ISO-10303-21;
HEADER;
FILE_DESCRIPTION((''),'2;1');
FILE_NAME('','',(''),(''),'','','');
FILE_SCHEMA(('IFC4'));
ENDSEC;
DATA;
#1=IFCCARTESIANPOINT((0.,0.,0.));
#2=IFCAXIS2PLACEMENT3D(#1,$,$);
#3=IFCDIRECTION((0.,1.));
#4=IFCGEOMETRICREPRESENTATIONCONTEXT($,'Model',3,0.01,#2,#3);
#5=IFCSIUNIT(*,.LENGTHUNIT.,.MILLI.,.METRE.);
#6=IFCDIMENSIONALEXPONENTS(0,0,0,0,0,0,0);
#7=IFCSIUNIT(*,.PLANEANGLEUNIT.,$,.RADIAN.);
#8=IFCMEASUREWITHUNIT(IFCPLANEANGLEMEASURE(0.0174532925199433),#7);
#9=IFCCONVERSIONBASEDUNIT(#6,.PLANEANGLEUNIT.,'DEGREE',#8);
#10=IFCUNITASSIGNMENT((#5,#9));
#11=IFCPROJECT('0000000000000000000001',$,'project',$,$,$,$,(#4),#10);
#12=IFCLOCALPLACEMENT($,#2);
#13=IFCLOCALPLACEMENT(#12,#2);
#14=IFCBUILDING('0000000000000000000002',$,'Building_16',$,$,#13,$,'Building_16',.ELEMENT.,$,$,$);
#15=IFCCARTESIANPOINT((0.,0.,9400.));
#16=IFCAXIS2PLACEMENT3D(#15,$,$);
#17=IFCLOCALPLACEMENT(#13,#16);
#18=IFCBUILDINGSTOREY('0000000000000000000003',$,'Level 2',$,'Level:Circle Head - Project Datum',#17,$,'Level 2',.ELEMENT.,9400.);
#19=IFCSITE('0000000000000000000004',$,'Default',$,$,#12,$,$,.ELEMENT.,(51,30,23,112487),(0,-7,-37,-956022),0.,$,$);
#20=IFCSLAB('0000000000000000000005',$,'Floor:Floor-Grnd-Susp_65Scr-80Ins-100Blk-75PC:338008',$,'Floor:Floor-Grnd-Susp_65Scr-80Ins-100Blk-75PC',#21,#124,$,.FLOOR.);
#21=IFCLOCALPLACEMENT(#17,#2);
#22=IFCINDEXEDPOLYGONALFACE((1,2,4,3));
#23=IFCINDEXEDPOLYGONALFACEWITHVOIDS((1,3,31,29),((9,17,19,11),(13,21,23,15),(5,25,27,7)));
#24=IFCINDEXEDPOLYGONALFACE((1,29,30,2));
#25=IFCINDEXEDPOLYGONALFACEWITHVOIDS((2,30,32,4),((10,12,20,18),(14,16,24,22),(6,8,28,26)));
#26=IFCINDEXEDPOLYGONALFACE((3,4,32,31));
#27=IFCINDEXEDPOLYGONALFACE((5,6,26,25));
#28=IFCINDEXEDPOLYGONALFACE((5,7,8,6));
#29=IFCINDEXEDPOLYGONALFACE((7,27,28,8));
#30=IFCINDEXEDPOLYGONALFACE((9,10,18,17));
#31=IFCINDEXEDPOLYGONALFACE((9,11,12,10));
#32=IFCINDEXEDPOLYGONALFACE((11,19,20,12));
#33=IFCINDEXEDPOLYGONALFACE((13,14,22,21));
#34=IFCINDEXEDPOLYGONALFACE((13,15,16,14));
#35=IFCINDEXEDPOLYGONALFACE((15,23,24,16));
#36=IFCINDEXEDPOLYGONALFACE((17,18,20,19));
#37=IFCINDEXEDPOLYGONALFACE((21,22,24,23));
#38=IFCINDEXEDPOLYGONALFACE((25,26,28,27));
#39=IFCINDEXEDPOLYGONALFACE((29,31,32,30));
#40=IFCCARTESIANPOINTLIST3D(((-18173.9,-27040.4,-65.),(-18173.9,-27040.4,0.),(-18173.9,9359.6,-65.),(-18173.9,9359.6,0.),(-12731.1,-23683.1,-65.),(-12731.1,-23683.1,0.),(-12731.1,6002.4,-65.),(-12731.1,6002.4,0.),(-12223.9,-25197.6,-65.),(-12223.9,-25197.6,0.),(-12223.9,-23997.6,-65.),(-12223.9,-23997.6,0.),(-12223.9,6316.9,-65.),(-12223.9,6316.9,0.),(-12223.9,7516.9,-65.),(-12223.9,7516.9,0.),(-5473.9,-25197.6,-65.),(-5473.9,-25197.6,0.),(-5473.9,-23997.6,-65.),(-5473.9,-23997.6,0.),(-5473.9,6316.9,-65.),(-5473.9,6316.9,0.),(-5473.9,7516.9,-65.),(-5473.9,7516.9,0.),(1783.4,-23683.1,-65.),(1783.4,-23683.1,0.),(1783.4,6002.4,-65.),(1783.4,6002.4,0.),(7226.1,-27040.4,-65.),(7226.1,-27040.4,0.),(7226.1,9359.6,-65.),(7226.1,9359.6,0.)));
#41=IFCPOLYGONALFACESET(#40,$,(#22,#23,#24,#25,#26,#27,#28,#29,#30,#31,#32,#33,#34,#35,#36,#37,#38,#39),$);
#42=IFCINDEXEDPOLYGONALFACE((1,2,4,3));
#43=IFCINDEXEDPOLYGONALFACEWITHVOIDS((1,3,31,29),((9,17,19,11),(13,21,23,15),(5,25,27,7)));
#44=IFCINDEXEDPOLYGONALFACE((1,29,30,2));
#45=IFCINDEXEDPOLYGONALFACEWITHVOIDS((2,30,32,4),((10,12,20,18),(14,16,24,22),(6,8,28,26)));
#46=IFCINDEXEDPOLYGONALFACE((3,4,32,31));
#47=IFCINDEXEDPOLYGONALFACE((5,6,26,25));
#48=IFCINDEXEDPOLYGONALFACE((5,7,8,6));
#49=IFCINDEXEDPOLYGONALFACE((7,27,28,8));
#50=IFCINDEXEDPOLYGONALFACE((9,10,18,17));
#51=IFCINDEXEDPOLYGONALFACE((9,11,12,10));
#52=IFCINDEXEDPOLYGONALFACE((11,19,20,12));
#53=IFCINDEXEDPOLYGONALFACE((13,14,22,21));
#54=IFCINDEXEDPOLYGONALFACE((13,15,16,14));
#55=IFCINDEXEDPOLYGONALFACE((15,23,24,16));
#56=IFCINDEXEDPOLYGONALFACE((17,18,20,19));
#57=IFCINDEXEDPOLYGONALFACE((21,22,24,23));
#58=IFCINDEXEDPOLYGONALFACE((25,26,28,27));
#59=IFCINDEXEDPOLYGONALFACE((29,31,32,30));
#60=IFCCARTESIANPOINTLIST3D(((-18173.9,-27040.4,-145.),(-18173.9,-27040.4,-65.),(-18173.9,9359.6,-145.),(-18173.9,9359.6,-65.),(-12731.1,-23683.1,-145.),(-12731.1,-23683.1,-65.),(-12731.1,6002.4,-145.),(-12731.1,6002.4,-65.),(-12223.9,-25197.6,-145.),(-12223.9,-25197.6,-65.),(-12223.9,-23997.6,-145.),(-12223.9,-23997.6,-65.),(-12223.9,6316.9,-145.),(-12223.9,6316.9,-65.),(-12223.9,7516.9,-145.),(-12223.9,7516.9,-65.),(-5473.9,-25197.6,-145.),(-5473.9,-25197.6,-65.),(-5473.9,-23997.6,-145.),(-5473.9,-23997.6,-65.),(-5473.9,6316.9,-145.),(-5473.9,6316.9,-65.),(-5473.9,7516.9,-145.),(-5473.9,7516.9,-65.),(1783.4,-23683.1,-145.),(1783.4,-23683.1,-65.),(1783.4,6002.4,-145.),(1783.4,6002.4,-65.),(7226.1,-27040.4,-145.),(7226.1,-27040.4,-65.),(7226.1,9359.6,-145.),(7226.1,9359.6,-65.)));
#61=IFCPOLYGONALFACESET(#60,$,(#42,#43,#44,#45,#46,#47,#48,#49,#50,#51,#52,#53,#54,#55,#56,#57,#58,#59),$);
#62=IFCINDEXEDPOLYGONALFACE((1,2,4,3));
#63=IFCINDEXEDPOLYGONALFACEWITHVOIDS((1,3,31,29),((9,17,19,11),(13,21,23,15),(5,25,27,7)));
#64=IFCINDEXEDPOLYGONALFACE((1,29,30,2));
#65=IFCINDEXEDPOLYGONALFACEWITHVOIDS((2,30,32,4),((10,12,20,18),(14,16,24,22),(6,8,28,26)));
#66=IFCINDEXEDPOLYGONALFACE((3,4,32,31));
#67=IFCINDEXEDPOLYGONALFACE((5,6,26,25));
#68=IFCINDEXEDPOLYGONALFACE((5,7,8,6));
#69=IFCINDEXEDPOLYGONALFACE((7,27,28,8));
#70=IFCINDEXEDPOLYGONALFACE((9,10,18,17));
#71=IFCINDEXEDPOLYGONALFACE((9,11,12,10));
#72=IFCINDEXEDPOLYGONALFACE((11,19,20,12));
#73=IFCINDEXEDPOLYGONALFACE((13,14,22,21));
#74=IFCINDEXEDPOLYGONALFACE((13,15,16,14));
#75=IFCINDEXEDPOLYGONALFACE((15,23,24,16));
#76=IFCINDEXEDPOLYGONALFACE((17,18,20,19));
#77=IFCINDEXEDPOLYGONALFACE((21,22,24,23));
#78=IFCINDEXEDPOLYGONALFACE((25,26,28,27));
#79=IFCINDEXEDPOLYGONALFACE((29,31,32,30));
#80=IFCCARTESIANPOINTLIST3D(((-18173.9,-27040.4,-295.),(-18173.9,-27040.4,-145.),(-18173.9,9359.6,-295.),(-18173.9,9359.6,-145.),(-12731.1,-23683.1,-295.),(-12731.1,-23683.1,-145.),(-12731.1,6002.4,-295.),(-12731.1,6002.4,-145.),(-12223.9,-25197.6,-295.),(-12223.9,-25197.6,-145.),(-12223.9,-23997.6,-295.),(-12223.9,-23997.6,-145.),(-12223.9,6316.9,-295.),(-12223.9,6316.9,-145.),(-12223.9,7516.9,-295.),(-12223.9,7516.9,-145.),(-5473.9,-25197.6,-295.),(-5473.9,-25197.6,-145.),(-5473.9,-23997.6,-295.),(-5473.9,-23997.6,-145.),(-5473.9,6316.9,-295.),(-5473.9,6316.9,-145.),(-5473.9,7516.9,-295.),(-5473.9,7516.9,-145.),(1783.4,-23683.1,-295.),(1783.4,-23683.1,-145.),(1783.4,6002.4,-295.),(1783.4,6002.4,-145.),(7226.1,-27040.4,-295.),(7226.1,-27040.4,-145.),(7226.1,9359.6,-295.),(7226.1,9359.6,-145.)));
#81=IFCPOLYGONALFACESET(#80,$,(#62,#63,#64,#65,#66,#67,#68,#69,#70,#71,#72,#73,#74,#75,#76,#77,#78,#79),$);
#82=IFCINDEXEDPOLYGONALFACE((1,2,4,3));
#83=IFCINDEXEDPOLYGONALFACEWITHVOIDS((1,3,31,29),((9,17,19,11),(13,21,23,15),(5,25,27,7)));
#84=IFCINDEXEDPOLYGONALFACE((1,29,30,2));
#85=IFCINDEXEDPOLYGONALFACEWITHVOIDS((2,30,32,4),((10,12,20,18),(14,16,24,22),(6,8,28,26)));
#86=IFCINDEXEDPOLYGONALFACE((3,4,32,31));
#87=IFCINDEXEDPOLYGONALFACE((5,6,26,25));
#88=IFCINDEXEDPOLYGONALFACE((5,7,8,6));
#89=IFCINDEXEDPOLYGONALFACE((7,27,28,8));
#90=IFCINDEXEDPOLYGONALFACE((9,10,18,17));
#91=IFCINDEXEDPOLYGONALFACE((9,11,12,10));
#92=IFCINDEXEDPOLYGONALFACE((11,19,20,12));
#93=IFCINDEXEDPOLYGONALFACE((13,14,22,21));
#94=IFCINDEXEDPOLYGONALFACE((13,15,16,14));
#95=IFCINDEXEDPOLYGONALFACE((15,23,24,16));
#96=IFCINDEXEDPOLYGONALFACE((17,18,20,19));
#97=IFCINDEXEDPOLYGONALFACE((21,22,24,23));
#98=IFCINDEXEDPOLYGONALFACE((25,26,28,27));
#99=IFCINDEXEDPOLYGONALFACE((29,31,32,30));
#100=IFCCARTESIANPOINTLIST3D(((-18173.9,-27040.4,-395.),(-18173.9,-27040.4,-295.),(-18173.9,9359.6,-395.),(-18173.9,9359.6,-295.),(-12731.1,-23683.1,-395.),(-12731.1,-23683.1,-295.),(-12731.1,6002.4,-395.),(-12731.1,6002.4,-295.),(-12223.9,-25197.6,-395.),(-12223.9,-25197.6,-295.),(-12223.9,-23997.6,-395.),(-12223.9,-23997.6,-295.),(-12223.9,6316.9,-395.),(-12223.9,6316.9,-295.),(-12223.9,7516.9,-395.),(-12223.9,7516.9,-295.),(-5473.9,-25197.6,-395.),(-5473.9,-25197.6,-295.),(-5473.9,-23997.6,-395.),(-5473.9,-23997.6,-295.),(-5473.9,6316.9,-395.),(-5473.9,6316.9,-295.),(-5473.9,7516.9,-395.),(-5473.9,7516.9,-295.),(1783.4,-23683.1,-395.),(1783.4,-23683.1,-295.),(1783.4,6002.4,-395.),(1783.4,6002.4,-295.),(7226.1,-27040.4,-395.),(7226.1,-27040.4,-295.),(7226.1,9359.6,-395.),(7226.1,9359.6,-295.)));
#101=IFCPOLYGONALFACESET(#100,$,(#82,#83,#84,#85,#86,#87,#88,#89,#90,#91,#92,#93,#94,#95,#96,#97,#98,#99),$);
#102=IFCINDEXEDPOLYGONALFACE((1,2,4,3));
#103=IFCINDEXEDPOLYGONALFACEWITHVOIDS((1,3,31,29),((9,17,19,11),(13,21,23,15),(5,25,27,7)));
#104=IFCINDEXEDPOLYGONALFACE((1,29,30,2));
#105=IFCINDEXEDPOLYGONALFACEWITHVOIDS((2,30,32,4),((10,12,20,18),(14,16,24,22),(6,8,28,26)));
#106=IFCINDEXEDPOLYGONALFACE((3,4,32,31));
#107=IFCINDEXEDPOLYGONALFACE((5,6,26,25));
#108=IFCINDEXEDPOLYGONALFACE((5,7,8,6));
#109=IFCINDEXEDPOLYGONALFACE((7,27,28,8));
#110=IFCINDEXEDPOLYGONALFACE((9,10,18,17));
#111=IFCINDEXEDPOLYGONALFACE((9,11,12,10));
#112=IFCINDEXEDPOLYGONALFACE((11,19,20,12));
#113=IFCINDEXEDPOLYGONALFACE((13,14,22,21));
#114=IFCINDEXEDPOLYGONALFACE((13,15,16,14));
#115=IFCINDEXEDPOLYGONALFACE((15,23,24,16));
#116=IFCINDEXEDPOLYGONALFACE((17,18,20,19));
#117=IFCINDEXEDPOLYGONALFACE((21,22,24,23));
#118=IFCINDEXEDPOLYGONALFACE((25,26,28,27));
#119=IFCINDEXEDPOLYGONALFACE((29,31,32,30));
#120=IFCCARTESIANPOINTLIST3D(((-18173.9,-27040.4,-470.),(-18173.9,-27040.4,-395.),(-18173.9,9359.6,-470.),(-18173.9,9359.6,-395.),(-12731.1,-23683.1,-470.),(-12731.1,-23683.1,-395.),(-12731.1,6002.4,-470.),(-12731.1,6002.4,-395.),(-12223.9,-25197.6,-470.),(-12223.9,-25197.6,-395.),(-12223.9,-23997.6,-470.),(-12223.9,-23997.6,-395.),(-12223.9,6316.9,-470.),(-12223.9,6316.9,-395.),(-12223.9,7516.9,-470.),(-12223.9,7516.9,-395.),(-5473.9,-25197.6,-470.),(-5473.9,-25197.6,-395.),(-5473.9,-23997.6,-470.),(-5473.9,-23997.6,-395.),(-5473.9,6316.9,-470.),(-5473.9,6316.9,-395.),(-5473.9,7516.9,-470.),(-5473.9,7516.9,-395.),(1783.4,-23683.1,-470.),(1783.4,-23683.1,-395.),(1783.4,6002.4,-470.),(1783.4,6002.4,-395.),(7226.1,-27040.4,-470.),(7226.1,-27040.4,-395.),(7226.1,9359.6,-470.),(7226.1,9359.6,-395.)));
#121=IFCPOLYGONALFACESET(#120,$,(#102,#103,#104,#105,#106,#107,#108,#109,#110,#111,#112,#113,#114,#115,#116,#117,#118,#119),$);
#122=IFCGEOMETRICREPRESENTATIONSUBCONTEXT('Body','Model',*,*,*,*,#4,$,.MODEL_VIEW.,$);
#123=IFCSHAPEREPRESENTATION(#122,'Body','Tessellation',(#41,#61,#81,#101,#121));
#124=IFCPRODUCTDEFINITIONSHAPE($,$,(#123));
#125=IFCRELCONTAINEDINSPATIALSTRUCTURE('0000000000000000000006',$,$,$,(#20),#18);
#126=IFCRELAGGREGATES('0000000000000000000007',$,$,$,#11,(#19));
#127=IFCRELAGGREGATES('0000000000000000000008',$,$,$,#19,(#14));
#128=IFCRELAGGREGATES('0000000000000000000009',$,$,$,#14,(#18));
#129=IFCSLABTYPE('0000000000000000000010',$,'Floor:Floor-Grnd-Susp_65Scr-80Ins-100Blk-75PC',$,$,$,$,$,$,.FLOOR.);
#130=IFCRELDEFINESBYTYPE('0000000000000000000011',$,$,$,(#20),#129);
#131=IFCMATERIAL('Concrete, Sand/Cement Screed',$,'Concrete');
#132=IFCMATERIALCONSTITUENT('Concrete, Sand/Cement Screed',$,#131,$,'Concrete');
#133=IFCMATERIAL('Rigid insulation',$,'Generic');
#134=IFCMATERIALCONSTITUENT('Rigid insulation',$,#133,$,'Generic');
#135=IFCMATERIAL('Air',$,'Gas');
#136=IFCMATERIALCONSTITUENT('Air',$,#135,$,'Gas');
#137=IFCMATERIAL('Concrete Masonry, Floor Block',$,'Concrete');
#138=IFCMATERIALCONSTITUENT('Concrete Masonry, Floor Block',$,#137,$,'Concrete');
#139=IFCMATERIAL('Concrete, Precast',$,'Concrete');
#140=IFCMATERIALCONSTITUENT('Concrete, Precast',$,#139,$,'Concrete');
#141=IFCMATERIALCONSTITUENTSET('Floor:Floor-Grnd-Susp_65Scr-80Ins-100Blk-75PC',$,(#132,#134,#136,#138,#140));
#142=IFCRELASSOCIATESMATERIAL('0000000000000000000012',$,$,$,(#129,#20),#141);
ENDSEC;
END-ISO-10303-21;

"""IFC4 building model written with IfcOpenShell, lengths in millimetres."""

from ifc_helpers import new_model, entity, si_unit, converted_unit, direction, frame, origin, place, context, subcontext, project, spatial, indexed_curve, outline, extrude, material, constituent, constituent_set, type_object, element, save


model = new_model("IFC4")

# Units and contexts
model_context = context("Model", 3, precision=0.01, world=origin(), true_north=direction((0.0, 1.0)))
body_context = subcontext(model_context, "Body", "Model", "MODEL_VIEW")
ifc_project = project(units=[si_unit("LENGTHUNIT", "METRE", prefix="MILLI"), converted_unit("PLANEANGLEUNIT", "DEGREE", entity("IfcPlaneAngleMeasure", 0.0174532925199433), si_unit("PLANEANGLEUNIT", "RADIAN"), dimensions=[0, 0, 0, 0, 0, 0, 0])], contexts=[model_context])

# Site, building, storey
site_placement = place(None, origin())
site = spatial("IfcSite", under=ifc_project, at=site_placement, Name="Default", CompositionType="ELEMENT", RefLatitude=(51, 30, 23, 112487), RefLongitude=(0, -7, -37, -956022), RefElevation=0.0)
building_placement = place(site_placement, origin())
building = spatial("IfcBuilding", under=site, at=building_placement, Name="Building_16", LongName="Building_16", CompositionType="ELEMENT")
storey_placement = place(building_placement, frame((0.0, 0.0, 9400.0)))
storey = spatial("IfcBuildingStorey", under=building, at=storey_placement, Name="Level 2", ObjectType="Level:Circle Head - Project Datum", LongName="Level 2", CompositionType="ELEMENT", Elevation=9400.0)

# Slab, openings
ifc_material_1 = material(Name="Concrete, Sand/Cement Screed", Category="Concrete")
ifc_constituent_1 = constituent(ifc_material_1, Name="Concrete, Sand/Cement Screed", Category="Concrete")
ifc_material_2 = material(Name="Rigid insulation", Category="Generic")
ifc_constituent_2 = constituent(ifc_material_2, Name="Rigid insulation", Category="Generic")
ifc_material_3 = material(Name="Air", Category="Gas")
ifc_constituent_3 = constituent(ifc_material_3, Name="Air", Category="Gas")
ifc_material_4 = material(Name="Concrete Masonry, Floor Block", Category="Concrete")
ifc_constituent_4 = constituent(ifc_material_4, Name="Concrete Masonry, Floor Block", Category="Concrete")
ifc_material_5 = material(Name="Concrete, Precast", Category="Concrete")
ifc_constituent_5 = constituent(ifc_material_5, Name="Concrete, Precast", Category="Concrete")
ifc_constituent_set_1 = constituent_set(constituents=[ifc_constituent_1, ifc_constituent_2, ifc_constituent_3, ifc_constituent_4, ifc_constituent_5], Name="Floor:Floor-Grnd-Susp_65Scr-80Ins-100Blk-75PC")
slab_type = type_object("IfcSlabType", Name="Floor:Floor-Grnd-Susp_65Scr-80Ins-100Blk-75PC", PredefinedType="FLOOR", material=ifc_constituent_set_1)
slab_placement = place(storey_placement, origin())
slab = element("IfcSlab", 1, at=slab_placement, inside=storey, type_object=slab_type, material=ifc_constituent_set_1, Name="Floor:Floor-Grnd-Susp_65Scr-80Ins-100Blk-75PC:338008", ObjectType="Floor:Floor-Grnd-Susp_65Scr-80Ins-100Blk-75PC", PredefinedType="FLOOR", context=body_context, shape_type="SweptSolid", body=[
    extrude(outline(indexed_curve([(-12700.0, -18200.0), (12700.0, -18200.0), (12700.0, 18200.0), (-12700.0, 18200.0), (-12700.0, -18200.0)], self_intersect=False), holes=[indexed_curve([(-7257.2, -14842.8), (-7257.2, 14842.8), (7257.3, 14842.8), (7257.3, -14842.8), (-7257.2, -14842.8)], self_intersect=False), indexed_curve([(6750.0, -15157.2), (6750.0, -16357.2), (0.0, -16357.2), (0.0, -15157.2), (6750.0, -15157.2)], self_intersect=False), indexed_curve([(6750.0, 15157.2), (0.0, 15157.2), (0.0, 16357.2), (6750.0, 16357.2), (6750.0, 15157.2)], self_intersect=False)]), frame((-5473.9, -8840.4, -65.0), z_axis=(0.0, 0.0, 1.0), x_axis=(-1.0, 0.0, 0.0)), (0.0, 0.0, 1.0), 65.0),
    extrude(outline(indexed_curve([(-12700.0, -18200.0), (12700.0, -18200.0), (12700.0, 18200.0), (-12700.0, 18200.0), (-12700.0, -18200.0)], self_intersect=False), holes=[indexed_curve([(-7257.2, -14842.8), (-7257.2, 14842.8), (7257.3, 14842.8), (7257.3, -14842.8), (-7257.2, -14842.8)], self_intersect=False), indexed_curve([(6750.0, -15157.2), (6750.0, -16357.2), (0.0, -16357.2), (0.0, -15157.2), (6750.0, -15157.2)], self_intersect=False), indexed_curve([(6750.0, 15157.2), (0.0, 15157.2), (0.0, 16357.2), (6750.0, 16357.2), (6750.0, 15157.2)], self_intersect=False)]), frame((-5473.9, -8840.4, -145.0), z_axis=(0.0, 0.0, 1.0), x_axis=(-1.0, 0.0, 0.0)), (0.0, 0.0, 1.0), 80.0),
    extrude(outline(indexed_curve([(-12700.0, -18200.0), (12700.0, -18200.0), (12700.0, 18200.0), (-12700.0, 18200.0), (-12700.0, -18200.0)], self_intersect=False), holes=[indexed_curve([(-7257.2, -14842.8), (-7257.2, 14842.8), (7257.3, 14842.8), (7257.3, -14842.8), (-7257.2, -14842.8)], self_intersect=False), indexed_curve([(6750.0, -15157.2), (6750.0, -16357.2), (0.0, -16357.2), (0.0, -15157.2), (6750.0, -15157.2)], self_intersect=False), indexed_curve([(6750.0, 15157.2), (0.0, 15157.2), (0.0, 16357.2), (6750.0, 16357.2), (6750.0, 15157.2)], self_intersect=False)]), frame((-5473.9, -8840.4, -295.0), z_axis=(0.0, 0.0, 1.0), x_axis=(-1.0, 0.0, 0.0)), (0.0, 0.0, 1.0), 150.0),
    extrude(outline(indexed_curve([(-12700.0, -18200.0), (12700.0, -18200.0), (12700.0, 18200.0), (-12700.0, 18200.0), (-12700.0, -18200.0)], self_intersect=False), holes=[indexed_curve([(-7257.2, -14842.8), (-7257.2, 14842.8), (7257.3, 14842.8), (7257.3, -14842.8), (-7257.2, -14842.8)], self_intersect=False), indexed_curve([(6750.0, -15157.2), (6750.0, -16357.2), (0.0, -16357.2), (0.0, -15157.2), (6750.0, -15157.2)], self_intersect=False), indexed_curve([(6750.0, 15157.2), (0.0, 15157.2), (0.0, 16357.2), (6750.0, 16357.2), (6750.0, 15157.2)], self_intersect=False)]), frame((-5473.9, -8840.4, -395.0), z_axis=(0.0, 0.0, 1.0), x_axis=(-1.0, 0.0, 0.0)), (0.0, 0.0, 1.0), 100.0),
    extrude(outline(indexed_curve([(-12700.0, -18200.0), (12700.0, -18200.0), (12700.0, 18200.0), (-12700.0, 18200.0), (-12700.0, -18200.0)], self_intersect=False), holes=[indexed_curve([(6750.0, 15157.2), (0.0, 15157.2), (0.0, 16357.2), (6750.0, 16357.2), (6750.0, 15157.2)], self_intersect=False), indexed_curve([(6750.0, -15157.2), (6750.0, -16357.2), (0.0, -16357.2), (0.0, -15157.2), (6750.0, -15157.2)], self_intersect=False), indexed_curve([(-7257.2, -14842.8), (-7257.2, 14842.8), (7257.3, 14842.8), (7257.3, -14842.8), (-7257.2, -14842.8)], self_intersect=False)]), frame((-5473.9, -8840.4, -470.0), z_axis=(0.0, 0.0, 1.0), x_axis=(-1.0, 0.0, 0.0)), (0.0, 0.0, 1.0), 75.0),
])
opening_1_placement = place(slab_placement, origin())
element("IfcOpeningElement", 2, at=opening_1_placement, cuts=slab, PredefinedType="OPENING", context=body_context, shape_type="SweptSolid", body=[
    extrude(outline(indexed_curve([(-3375.0, -600.0), (3375.0, -600.0), (3375.0, 600.0), (-3375.0, 600.0), (-3375.0, -600.0)], self_intersect=False)), frame((-8848.9, -24597.6, 0.0), z_axis=(0.0, 0.0, -1.0), x_axis=(1.0, 0.0, 0.0)), (0.0, 0.0, 1.0), 470.0),
])
opening_2_placement = place(slab_placement, origin())
element("IfcOpeningElement", 3, at=opening_2_placement, cuts=slab, PredefinedType="OPENING", context=body_context, shape_type="SweptSolid", body=[
    extrude(outline(indexed_curve([(-600.0, 3375.0), (-600.0, -3375.0), (600.0, -3375.0), (600.0, 3375.0), (-600.0, 3375.0)], self_intersect=False)), frame((-8848.9, 6916.9, 0.0), z_axis=(0.0, 0.0, 1.0), x_axis=(0.0, 1.0, 0.0)), (0.0, 0.0, -1.0), 470.0),
])
opening_3_placement = place(slab_placement, origin())
element("IfcOpeningElement", 4, at=opening_3_placement, cuts=slab, PredefinedType="OPENING", context=body_context, shape_type="SweptSolid", body=[
    extrude(outline(indexed_curve([(-14842.8, 7257.2), (-14842.8, -7257.2), (14842.8, -7257.2), (14842.8, 7257.2), (-14842.8, 7257.2)], self_intersect=False)), frame((-5473.9, -8840.4, 0.0), z_axis=(0.0, 0.0, 1.0), x_axis=(0.0, -1.0, 0.0)), (0.0, 0.0, -1.0), 470.0),
])

save(model, "model.ifc")
